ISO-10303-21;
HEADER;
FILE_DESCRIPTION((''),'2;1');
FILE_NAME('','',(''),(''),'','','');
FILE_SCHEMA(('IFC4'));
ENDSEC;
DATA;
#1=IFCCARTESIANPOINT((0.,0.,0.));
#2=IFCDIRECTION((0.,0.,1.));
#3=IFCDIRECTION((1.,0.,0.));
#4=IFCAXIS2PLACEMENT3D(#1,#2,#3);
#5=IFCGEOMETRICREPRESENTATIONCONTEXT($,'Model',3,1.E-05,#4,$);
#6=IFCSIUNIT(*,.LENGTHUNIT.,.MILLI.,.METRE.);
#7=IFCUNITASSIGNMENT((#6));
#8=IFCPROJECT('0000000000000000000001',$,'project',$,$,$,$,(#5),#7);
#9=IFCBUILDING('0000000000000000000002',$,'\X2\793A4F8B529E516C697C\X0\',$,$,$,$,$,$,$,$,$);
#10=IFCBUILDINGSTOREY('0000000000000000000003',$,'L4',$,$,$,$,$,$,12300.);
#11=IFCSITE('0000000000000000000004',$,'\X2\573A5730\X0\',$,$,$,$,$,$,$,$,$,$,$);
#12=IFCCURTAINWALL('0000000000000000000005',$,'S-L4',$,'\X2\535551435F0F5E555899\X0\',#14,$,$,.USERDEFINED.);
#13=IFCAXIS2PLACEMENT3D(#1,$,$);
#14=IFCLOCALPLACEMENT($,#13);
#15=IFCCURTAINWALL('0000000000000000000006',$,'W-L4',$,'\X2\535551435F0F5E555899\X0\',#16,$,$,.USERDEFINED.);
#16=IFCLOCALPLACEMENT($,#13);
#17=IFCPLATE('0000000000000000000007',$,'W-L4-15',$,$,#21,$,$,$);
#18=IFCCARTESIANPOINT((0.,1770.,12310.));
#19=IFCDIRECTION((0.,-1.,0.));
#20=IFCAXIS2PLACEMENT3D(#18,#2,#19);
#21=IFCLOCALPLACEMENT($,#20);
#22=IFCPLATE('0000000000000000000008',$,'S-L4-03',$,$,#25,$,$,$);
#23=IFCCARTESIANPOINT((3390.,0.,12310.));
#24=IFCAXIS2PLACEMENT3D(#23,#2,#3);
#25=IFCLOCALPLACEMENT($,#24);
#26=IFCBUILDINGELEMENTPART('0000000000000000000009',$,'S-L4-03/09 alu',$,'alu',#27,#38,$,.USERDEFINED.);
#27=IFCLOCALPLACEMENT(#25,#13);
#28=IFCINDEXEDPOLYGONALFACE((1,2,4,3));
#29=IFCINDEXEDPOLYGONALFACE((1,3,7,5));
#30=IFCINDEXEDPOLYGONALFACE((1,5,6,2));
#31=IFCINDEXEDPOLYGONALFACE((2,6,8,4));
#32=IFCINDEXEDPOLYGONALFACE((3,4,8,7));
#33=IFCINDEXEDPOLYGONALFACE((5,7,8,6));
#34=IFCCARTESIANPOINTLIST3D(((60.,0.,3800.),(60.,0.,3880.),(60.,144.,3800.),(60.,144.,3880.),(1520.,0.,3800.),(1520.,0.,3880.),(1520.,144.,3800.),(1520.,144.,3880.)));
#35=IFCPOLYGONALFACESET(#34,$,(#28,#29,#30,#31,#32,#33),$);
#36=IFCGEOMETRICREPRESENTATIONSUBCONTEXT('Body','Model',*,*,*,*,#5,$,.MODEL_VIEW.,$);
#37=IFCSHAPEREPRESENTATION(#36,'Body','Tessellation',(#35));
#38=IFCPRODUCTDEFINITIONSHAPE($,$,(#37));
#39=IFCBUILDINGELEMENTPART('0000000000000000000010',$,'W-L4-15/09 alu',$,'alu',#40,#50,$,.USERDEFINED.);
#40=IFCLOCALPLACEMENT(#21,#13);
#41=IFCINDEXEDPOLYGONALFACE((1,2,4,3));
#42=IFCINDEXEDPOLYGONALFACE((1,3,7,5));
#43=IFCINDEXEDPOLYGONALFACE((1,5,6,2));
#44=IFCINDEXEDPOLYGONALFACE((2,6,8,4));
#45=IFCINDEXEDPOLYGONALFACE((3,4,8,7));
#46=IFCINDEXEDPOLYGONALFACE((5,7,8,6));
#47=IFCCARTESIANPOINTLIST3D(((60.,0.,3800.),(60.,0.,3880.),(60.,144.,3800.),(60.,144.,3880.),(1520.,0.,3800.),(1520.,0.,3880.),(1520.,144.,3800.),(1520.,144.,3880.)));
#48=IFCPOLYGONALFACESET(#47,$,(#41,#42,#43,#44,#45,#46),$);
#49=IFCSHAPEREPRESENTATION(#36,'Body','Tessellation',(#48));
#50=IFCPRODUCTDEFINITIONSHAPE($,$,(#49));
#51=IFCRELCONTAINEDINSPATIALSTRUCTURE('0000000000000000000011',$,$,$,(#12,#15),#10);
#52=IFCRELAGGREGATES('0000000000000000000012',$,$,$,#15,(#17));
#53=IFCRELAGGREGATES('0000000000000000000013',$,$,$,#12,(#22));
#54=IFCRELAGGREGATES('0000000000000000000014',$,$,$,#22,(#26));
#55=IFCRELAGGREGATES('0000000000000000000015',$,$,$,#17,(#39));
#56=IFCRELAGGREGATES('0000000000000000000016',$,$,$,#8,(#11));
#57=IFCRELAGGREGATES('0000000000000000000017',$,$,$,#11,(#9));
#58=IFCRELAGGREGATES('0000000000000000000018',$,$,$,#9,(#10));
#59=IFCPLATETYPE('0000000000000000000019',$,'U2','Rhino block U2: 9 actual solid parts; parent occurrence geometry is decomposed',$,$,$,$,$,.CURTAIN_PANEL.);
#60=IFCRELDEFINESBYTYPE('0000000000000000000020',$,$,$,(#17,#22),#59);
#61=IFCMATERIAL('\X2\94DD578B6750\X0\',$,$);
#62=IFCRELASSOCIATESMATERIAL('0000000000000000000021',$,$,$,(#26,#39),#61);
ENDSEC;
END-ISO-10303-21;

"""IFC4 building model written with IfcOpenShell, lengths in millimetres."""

from ifc_helpers import new_model, si_unit, frame, frame_2d, origin, origin_with_axes, place, context, subcontext, project, spatial, rectangle, extrude, source, transform, mapped, material, type_object, element, aggregate, save


model = new_model("IFC4")

# Units and contexts
model_context = context("Model", 3, precision=1e-05, world=origin_with_axes())
body_context = subcontext(model_context, "Body", "Model", "MODEL_VIEW")
ifc_project = project(units=[si_unit("LENGTHUNIT", "METRE", prefix="MILLI")], contexts=[model_context])

# Site, building, storey
site = spatial("IfcSite", under=ifc_project, Name="场地")
building = spatial("IfcBuilding", under=site, Name="示例办公楼")
storey = spatial("IfcBuildingStorey", under=building, Name="L4", Elevation=12300.0)

# Curtain wall
curtain_wall_1 = element("IfcCurtainWall", 1, inside=storey, Name="S-L4", ObjectType="单元式幕墙", PredefinedType="USERDEFINED")
plate_type = type_object("IfcPlateType", Name="U2", Description="Rhino block U2: 9 actual solid parts; parent occurrence geometry is decomposed", PredefinedType="CURTAIN_PANEL")
ifc_material_1 = material(Name="铝型材")

# Curtain wall, plate
curtain_wall_2 = element("IfcCurtainWall", 2, inside=storey, Name="W-L4", ObjectType="单元式幕墙", PredefinedType="USERDEFINED")
plate_1_placement = place(None, frame((0.0, 1770.0, 12310.0), z_axis=(0.0, 0.0, 1.0), x_axis=(0.0, -1.0, 0.0)))
plate_1 = element("IfcPlate", 3, at=plate_1_placement, type_object=plate_type, Name="W-L4-15")
aggregate(curtain_wall_2, [plate_1])

# Plate
plate_2_placement = place(None, frame((3390.0, 0.0, 12310.0), z_axis=(0.0, 0.0, 1.0), x_axis=(1.0, 0.0, 0.0)))
plate_2 = element("IfcPlate", 4, at=plate_2_placement, type_object=plate_type, Name="S-L4-03")
aggregate(curtain_wall_1, [plate_2])

# Building element parts
shared_shape_1 = source(origin(), body_context, "Body", "SweptSolid", [
    extrude(rectangle(XDim=1460.0, YDim=144.0, at=frame_2d((790.0, 72.0))), frame((0.0, 0.0, 3800.0)), (0.0, 0.0, 1.0), 80.0),
])
building_element_part_1_placement = place(plate_2_placement, origin())
building_element_part_1 = element("IfcBuildingElementPart", 5, at=building_element_part_1_placement, material=ifc_material_1, Name="S-L4-03/09 alu", ObjectType="alu", PredefinedType="USERDEFINED", context=body_context, shape_type="MappedRepresentation", body=[
    mapped(shared_shape_1, transform((0.0, 0.0, 0.0))),
])
aggregate(plate_2, [building_element_part_1])
building_element_part_2_placement = place(plate_1_placement, origin())
building_element_part_2 = element("IfcBuildingElementPart", 6, at=building_element_part_2_placement, material=ifc_material_1, Name="W-L4-15/09 alu", ObjectType="alu", PredefinedType="USERDEFINED", context=body_context, shape_type="MappedRepresentation", body=[
    mapped(shared_shape_1, transform((0.0, 0.0, 0.0))),
])
aggregate(plate_1, [building_element_part_2])

save(model, "model.ifc")
